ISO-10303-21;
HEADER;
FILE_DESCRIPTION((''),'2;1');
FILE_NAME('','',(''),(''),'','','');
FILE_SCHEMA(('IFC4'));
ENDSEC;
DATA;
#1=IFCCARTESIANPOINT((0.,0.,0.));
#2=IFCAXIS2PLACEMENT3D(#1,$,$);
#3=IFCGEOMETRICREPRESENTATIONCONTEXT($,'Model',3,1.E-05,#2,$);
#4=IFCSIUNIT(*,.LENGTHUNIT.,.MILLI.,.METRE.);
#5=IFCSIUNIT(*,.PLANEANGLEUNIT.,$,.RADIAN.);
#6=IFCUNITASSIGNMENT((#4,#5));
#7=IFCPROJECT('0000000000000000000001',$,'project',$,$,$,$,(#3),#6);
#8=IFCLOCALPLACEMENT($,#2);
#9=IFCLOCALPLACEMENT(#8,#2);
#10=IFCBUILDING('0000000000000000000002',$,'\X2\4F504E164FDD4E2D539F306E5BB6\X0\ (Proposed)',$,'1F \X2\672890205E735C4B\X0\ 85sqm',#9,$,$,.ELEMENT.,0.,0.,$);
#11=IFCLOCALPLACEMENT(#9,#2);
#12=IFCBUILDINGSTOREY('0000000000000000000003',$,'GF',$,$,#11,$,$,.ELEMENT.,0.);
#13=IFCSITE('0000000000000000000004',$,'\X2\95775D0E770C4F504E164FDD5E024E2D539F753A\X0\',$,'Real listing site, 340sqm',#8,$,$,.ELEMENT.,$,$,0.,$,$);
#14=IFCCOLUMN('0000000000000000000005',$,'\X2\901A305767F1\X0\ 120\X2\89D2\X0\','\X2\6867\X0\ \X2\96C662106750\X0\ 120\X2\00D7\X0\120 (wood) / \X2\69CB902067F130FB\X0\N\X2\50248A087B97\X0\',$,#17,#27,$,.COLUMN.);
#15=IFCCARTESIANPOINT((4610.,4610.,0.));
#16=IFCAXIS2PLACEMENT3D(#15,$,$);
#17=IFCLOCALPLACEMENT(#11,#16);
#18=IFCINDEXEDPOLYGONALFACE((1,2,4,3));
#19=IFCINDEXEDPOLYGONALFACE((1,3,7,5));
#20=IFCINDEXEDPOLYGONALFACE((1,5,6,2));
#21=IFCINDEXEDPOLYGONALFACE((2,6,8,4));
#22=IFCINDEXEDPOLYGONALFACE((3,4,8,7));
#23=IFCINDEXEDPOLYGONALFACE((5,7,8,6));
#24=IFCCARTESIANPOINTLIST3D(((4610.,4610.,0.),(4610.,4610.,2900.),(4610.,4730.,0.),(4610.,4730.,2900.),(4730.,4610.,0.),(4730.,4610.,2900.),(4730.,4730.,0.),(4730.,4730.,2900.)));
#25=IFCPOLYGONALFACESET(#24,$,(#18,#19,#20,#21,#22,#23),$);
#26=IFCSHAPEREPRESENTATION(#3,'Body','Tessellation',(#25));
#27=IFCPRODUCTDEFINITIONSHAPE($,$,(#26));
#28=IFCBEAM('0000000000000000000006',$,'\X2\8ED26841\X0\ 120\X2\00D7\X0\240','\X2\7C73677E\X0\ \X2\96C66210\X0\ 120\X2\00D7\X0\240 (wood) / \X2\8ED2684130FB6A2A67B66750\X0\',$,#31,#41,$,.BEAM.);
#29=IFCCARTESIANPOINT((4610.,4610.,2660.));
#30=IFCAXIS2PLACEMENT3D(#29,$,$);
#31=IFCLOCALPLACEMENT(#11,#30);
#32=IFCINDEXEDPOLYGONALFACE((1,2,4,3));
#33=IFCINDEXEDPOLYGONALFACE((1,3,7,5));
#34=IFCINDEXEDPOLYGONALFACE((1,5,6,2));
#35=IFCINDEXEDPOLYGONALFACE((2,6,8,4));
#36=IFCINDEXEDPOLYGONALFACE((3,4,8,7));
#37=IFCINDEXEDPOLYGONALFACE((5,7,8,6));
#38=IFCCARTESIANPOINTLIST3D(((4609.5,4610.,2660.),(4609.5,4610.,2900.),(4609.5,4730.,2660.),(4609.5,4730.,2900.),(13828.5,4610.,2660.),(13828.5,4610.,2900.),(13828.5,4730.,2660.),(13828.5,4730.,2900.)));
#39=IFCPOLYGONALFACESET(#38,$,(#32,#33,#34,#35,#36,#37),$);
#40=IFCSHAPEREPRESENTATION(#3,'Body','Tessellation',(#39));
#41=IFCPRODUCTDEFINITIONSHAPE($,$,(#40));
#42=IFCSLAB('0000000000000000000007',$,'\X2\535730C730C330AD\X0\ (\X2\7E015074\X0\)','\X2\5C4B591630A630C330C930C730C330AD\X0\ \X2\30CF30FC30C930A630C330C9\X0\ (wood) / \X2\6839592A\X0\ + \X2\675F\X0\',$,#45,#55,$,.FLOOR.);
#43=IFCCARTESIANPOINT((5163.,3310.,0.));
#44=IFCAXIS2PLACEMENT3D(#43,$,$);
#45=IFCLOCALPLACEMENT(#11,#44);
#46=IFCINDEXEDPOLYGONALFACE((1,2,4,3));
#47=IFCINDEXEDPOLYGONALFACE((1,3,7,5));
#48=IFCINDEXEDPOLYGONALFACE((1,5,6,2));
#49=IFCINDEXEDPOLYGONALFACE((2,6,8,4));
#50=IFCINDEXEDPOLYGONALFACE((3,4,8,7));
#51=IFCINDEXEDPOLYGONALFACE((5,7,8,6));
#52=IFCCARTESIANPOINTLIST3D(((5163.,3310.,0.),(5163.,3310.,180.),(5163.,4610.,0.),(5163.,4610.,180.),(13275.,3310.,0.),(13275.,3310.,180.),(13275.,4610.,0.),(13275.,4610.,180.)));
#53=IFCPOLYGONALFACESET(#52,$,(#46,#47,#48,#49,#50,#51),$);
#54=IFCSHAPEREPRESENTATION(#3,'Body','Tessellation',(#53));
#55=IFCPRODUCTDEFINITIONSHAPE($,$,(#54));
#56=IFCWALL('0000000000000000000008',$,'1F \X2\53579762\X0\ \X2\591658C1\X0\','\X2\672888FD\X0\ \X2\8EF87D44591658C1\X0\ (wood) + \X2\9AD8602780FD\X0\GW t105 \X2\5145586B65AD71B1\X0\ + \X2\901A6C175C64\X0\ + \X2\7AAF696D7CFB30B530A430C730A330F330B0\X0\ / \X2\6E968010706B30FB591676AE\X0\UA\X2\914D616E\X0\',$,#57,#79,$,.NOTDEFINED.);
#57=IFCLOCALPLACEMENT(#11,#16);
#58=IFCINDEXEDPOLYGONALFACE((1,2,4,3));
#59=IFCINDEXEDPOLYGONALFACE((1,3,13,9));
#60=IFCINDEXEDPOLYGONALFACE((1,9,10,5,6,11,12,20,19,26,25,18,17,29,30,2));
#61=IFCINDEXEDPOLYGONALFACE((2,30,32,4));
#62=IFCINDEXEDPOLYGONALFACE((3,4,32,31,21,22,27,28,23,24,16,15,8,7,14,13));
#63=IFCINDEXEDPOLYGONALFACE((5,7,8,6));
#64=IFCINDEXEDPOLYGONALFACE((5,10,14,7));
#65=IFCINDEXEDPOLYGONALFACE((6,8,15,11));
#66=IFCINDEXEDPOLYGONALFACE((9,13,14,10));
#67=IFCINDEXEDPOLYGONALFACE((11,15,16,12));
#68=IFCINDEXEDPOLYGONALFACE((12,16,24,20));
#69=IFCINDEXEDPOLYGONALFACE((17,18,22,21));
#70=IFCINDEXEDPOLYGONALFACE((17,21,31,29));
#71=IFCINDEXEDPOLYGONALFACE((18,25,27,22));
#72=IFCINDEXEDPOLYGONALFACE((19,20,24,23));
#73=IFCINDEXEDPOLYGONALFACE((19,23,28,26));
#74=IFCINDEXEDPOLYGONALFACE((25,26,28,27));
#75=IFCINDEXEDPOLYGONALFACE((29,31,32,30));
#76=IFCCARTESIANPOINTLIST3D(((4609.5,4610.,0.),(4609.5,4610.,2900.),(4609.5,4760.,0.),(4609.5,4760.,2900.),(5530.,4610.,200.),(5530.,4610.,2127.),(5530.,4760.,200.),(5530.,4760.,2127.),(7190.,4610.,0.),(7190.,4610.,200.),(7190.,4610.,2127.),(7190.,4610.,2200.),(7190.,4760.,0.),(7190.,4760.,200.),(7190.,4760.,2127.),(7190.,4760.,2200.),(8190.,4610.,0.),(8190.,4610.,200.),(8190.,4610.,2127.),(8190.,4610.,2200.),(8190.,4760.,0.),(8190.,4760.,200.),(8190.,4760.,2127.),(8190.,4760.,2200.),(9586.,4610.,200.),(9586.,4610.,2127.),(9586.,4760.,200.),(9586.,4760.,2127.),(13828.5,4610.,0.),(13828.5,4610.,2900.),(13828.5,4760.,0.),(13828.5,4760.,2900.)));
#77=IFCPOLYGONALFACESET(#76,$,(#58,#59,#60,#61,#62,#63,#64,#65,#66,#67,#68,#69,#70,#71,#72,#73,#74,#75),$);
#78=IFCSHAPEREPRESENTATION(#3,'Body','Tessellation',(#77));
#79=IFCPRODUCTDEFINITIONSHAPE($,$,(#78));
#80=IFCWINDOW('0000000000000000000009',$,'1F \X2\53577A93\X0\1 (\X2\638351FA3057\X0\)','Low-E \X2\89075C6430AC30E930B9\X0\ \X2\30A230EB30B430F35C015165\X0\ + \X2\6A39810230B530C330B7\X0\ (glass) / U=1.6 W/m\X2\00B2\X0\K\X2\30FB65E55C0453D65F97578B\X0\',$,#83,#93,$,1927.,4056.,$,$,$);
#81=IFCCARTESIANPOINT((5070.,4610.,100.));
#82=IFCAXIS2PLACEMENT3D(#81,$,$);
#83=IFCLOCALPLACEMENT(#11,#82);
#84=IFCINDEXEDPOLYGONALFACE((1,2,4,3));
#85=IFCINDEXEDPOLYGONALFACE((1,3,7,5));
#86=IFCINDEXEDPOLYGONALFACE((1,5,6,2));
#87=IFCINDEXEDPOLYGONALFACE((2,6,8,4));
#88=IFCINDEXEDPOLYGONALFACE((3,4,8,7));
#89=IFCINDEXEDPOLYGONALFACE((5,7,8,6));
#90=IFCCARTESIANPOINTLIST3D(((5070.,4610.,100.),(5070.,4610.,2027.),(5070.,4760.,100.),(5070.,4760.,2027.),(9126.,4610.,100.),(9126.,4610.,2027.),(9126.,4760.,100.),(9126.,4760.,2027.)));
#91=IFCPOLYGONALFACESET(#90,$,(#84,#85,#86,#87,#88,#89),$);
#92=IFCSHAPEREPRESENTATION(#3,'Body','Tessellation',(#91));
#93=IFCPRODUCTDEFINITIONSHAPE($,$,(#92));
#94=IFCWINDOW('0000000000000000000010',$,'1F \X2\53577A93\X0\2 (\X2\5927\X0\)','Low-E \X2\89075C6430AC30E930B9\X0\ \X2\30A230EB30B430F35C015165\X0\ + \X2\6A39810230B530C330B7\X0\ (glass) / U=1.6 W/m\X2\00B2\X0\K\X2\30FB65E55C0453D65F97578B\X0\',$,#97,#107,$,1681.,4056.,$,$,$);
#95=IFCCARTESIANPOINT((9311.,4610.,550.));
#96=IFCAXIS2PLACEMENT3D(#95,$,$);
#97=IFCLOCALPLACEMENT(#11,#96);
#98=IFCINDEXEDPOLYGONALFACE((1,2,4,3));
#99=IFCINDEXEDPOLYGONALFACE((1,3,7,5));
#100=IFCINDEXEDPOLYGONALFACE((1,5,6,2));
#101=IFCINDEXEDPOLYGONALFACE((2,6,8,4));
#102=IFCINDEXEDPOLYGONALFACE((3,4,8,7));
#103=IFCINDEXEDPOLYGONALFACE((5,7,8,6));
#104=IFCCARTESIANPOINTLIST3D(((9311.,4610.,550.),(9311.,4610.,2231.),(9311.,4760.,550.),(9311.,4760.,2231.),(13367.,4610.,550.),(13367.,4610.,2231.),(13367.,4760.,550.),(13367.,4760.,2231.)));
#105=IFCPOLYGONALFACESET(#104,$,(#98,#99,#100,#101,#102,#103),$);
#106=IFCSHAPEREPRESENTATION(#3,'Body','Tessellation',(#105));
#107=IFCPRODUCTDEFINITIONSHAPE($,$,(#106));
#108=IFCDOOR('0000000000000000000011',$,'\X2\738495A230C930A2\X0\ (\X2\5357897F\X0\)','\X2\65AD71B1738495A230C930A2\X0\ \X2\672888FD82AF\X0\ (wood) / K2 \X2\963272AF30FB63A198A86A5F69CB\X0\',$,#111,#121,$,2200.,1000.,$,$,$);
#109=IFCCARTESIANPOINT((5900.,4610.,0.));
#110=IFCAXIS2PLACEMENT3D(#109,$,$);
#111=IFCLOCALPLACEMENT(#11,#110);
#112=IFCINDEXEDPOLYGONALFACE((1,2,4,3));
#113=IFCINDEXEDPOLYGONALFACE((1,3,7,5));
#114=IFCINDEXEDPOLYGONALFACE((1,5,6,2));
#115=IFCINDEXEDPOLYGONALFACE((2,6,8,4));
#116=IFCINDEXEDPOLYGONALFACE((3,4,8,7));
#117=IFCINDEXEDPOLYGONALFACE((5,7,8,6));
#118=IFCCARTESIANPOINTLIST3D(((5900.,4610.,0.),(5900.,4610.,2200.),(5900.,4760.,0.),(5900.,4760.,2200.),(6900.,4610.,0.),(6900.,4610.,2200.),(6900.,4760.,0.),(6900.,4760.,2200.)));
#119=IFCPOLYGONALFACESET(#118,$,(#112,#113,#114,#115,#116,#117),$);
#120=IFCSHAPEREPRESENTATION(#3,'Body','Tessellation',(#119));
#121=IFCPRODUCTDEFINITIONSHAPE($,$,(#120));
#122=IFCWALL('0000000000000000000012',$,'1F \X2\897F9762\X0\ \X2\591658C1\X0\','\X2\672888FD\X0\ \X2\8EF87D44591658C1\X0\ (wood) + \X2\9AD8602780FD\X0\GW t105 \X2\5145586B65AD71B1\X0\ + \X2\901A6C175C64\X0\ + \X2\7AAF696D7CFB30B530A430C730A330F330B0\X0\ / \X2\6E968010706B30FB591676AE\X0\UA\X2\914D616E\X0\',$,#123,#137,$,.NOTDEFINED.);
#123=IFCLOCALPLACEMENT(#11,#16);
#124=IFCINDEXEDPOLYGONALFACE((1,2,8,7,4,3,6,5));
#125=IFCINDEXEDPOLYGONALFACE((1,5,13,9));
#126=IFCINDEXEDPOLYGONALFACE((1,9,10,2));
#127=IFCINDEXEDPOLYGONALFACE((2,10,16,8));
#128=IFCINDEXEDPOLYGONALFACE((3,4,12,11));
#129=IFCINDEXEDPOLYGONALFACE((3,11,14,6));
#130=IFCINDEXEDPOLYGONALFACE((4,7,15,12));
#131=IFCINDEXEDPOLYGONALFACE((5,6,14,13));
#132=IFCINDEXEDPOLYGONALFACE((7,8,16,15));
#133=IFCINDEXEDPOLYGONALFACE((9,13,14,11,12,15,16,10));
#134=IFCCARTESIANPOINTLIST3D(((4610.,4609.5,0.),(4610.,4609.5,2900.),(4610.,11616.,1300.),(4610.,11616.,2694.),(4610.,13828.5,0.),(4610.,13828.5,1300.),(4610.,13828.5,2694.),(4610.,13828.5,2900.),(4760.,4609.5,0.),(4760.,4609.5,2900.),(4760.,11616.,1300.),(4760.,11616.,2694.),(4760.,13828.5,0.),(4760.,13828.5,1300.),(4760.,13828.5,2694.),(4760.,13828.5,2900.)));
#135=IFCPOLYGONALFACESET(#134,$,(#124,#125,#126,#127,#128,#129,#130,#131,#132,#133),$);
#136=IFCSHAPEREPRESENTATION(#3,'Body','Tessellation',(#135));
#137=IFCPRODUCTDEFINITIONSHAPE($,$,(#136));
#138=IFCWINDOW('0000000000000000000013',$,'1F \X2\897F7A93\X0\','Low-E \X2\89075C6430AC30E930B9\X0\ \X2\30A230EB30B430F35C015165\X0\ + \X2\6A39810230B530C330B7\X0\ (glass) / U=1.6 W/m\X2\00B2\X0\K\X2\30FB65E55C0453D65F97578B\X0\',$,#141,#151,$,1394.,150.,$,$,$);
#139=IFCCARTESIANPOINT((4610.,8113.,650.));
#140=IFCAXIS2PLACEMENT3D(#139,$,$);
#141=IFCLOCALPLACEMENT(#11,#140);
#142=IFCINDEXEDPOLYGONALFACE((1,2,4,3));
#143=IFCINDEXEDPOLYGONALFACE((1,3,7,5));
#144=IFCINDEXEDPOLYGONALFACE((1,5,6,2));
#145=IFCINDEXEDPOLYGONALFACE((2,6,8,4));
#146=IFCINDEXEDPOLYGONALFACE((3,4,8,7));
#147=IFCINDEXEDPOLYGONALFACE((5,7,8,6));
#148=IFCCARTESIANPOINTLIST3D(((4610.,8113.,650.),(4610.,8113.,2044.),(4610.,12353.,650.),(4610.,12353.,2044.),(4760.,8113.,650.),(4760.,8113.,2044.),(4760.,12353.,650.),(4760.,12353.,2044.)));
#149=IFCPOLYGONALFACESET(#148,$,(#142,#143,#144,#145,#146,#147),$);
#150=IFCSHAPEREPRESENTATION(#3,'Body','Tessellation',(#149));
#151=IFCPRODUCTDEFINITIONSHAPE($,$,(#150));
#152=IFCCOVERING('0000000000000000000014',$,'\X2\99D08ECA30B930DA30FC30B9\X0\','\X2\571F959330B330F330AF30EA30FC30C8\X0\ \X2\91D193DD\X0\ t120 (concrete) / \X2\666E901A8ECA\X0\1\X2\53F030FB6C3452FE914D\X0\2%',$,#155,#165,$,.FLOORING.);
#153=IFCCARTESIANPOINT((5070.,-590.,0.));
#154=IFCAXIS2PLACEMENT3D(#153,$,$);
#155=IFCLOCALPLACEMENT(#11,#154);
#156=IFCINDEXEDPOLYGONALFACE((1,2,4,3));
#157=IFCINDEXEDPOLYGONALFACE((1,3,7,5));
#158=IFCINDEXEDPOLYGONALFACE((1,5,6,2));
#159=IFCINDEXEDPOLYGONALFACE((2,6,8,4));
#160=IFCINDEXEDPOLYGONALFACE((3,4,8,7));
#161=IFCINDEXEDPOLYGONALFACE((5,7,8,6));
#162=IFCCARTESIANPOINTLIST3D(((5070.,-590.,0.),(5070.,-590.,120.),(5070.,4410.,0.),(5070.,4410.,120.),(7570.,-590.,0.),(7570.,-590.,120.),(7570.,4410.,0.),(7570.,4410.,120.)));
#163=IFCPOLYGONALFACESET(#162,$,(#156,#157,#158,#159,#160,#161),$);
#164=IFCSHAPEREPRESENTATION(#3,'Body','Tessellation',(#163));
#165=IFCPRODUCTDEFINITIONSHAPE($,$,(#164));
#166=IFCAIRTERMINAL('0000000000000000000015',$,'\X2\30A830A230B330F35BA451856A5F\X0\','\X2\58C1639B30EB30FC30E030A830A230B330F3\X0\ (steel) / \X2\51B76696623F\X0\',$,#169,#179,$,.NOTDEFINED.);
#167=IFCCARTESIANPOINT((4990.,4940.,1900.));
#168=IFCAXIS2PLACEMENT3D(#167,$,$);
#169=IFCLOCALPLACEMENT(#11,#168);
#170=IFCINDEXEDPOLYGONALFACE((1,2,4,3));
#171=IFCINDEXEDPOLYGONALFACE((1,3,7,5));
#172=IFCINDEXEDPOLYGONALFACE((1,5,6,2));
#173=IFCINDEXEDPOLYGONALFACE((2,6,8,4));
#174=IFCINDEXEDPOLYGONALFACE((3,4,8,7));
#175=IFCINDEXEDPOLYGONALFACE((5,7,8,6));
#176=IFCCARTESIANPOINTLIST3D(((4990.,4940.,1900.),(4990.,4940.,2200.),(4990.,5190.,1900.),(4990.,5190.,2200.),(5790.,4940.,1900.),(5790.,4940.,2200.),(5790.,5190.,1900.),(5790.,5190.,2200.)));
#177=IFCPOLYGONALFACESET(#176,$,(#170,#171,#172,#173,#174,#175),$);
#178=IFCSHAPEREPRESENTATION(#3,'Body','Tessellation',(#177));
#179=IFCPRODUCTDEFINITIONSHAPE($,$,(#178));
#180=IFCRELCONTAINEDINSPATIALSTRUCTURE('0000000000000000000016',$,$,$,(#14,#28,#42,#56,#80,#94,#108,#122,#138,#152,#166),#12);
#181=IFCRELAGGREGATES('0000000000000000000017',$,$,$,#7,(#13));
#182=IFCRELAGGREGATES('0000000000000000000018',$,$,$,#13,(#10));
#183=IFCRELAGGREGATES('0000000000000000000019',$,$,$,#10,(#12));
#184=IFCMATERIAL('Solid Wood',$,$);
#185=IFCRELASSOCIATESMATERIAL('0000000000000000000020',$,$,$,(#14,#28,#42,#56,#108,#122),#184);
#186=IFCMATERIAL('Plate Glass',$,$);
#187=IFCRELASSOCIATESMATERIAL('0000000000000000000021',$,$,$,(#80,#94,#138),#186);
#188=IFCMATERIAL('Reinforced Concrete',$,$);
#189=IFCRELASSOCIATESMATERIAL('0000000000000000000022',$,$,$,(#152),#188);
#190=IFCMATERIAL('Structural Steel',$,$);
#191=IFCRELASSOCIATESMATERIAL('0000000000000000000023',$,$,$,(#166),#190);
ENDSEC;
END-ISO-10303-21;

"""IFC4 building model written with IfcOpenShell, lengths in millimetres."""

from ifc_helpers import new_model, si_unit, frame, frame_2d, origin, place, context, project, spatial, rectangle, extrude, material, element, fill, save


model = new_model("IFC4")

# Units and contexts
model_context = context("Model", 3, precision=1e-05, world=origin())
ifc_project = project(units=[si_unit("LENGTHUNIT", "METRE", prefix="MILLI"), si_unit("PLANEANGLEUNIT", "RADIAN")], contexts=[model_context])

# Site, building, storey
site_placement = place(None, origin())
site = spatial("IfcSite", under=ifc_project, at=site_placement, Name="長崎県佐世保市中原町", ObjectType="Real listing site, 340sqm", CompositionType="ELEMENT", RefElevation=0.0)
building_placement = place(site_placement, origin())
building = spatial("IfcBuilding", under=site, at=building_placement, Name="佐世保中原の家 (Proposed)", ObjectType="1F 木造平屋 85sqm", CompositionType="ELEMENT", ElevationOfRefHeight=0.0, ElevationOfTerrain=0.0)
storey_placement = place(building_placement, origin())
storey = spatial("IfcBuildingStorey", under=building, at=storey_placement, Name="GF", CompositionType="ELEMENT", Elevation=0.0)

# Column
ifc_material_1 = material(Name="Solid Wood")
column_1_placement = place(storey_placement, frame((4610.0, 4610.0, 0.0)))
element("IfcColumn", 1, at=column_1_placement, inside=storey, material=ifc_material_1, Name="通し柱 120角", Description="桧 集成材 120×120 (wood) / 構造柱・N値計算", PredefinedType="COLUMN", context=model_context, shape_type="SweptSolid", body=[
    extrude(rectangle(XDim=120.0, YDim=120.0, at=frame_2d((60.0, 60.0))), frame((4610.0, 4610.0, 0.0)), (0.0, 0.0, 1.0), 2900.0),
])

# Beam
beam_1_placement = place(storey_placement, frame((4610.0, 4610.0, 2660.0)))
element("IfcBeam", 2, at=beam_1_placement, inside=storey, material=ifc_material_1, Name="軒桁 120×240", Description="米松 集成 120×240 (wood) / 軒桁・横架材", PredefinedType="BEAM", context=model_context, shape_type="SweptSolid", body=[
    extrude(rectangle(XDim=9219.0, YDim=120.0, at=frame_2d((4609.0, 60.0))), frame((4610.0, 4610.0, 2660.0)), (0.0, 0.0, 1.0), 240.0),
])

# Slab
ifc_material_2 = material(Name="Reinforced Concrete")
slab_1_placement = place(storey_placement, frame((5163.0, 3310.0, 0.0)))
element("IfcSlab", 3, at=slab_1_placement, inside=storey, material=ifc_material_1, Name="南デッキ (縁側)", Description="屋外ウッドデッキ ハードウッド (wood) / 根太 + 束", PredefinedType="FLOOR", context=model_context, shape_type="SweptSolid", body=[
    extrude(rectangle(XDim=8112.0, YDim=1300.0, at=frame_2d((4056.0, 650.0))), frame((5163.0, 3310.0, 0.0)), (0.0, 0.0, 1.0), 180.0),
])

# Wall, openings, windows, door
wall_1_placement = place(storey_placement, frame((4610.0, 4610.0, 0.0)))
wall_1 = element("IfcWall", 4, at=wall_1_placement, inside=storey, material=ifc_material_1, Name="1F 南面 外壁", Description="木製 軸組外壁 (wood) + 高性能GW t105 充填断熱 + 通気層 + 窯業系サイディング / 準耐火・外皮UA配慮", PredefinedType="NOTDEFINED", context=model_context, shape_type="SweptSolid", body=[
    extrude(rectangle(XDim=9219.0, YDim=150.0, at=frame_2d((4609.0, 75.0))), frame((4610.0, 4610.0, 0.0)), (0.0, 0.0, 1.0), 2900.0),
])
opening_1_placement = place(storey_placement, frame((5070.0, 4610.0, 100.0)))
opening_1 = element("IfcOpeningElement", 5, at=opening_1_placement, cuts=wall_1, PredefinedType="NOTDEFINED", context=model_context, shape_type="SweptSolid", body=[
    extrude(rectangle(XDim=4056.0, YDim=150.0, at=frame_2d((2028.0, 75.0))), frame((5070.0, 4610.0, 100.0)), (0.0, 0.0, 1.0), 1927.0),
])
opening_2_placement = place(storey_placement, frame((9311.0, 4610.0, 550.0)))
opening_2 = element("IfcOpeningElement", 6, at=opening_2_placement, cuts=wall_1, PredefinedType="NOTDEFINED", context=model_context, shape_type="SweptSolid", body=[
    extrude(rectangle(XDim=4056.0, YDim=150.0, at=frame_2d((2028.0, 75.0))), frame((9311.0, 4610.0, 550.0)), (0.0, 0.0, 1.0), 1681.0),
])
opening_3_placement = place(storey_placement, frame((5900.0, 4610.0, 0.0)))
opening_3 = element("IfcOpeningElement", 7, at=opening_3_placement, cuts=wall_1, PredefinedType="NOTDEFINED", context=model_context, shape_type="SweptSolid", body=[
    extrude(rectangle(XDim=1000.0, YDim=150.0, at=frame_2d((500.0, 75.0))), frame((5900.0, 4610.0, 0.0)), (0.0, 0.0, 1.0), 2200.0),
])
ifc_material_3 = material(Name="Plate Glass")
window_1_placement = place(storey_placement, frame((5070.0, 4610.0, 100.0)))
window_1 = element("IfcWindow", 8, at=window_1_placement, inside=storey, material=ifc_material_3, Name="1F 南窓1 (掃出し)", Description="Low-E 複層ガラス アルゴン封入 + 樹脂サッシ (glass) / U=1.6 W/m²K・日射取得型", OverallHeight=1927.0, OverallWidth=4056.0, context=model_context, shape_type="SweptSolid", body=[
    extrude(rectangle(XDim=4056.0, YDim=150.0, at=frame_2d((2028.0, 75.0))), frame((5070.0, 4610.0, 100.0)), (0.0, 0.0, 1.0), 1927.0),
])
fill(opening_1, window_1)
window_2_placement = place(storey_placement, frame((9311.0, 4610.0, 550.0)))
window_2 = element("IfcWindow", 9, at=window_2_placement, inside=storey, material=ifc_material_3, Name="1F 南窓2 (大)", Description="Low-E 複層ガラス アルゴン封入 + 樹脂サッシ (glass) / U=1.6 W/m²K・日射取得型", OverallHeight=1681.0, OverallWidth=4056.0, context=model_context, shape_type="SweptSolid", body=[
    extrude(rectangle(XDim=4056.0, YDim=150.0, at=frame_2d((2028.0, 75.0))), frame((9311.0, 4610.0, 550.0)), (0.0, 0.0, 1.0), 1681.0),
])
fill(opening_2, window_2)
door_placement = place(storey_placement, frame((5900.0, 4610.0, 0.0)))
door = element("IfcDoor", 10, at=door_placement, inside=storey, material=ifc_material_1, Name="玄関ドア (南西)", Description="断熱玄関ドア 木製芯 (wood) / K2 防犯・採風機構", OverallHeight=2200.0, OverallWidth=1000.0, context=model_context, shape_type="SweptSolid", body=[
    extrude(rectangle(XDim=1000.0, YDim=150.0, at=frame_2d((500.0, 75.0))), frame((5900.0, 4610.0, 0.0)), (0.0, 0.0, 1.0), 2200.0),
])
fill(opening_3, door)

# Wall, opening, window
wall_2_placement = place(storey_placement, frame((4610.0, 4610.0, 0.0)))
wall_2 = element("IfcWall", 11, at=wall_2_placement, inside=storey, material=ifc_material_1, Name="1F 西面 外壁", Description="木製 軸組外壁 (wood) + 高性能GW t105 充填断熱 + 通気層 + 窯業系サイディング / 準耐火・外皮UA配慮", PredefinedType="NOTDEFINED", context=model_context, shape_type="SweptSolid", body=[
    extrude(rectangle(XDim=150.0, YDim=9219.0, at=frame_2d((75.0, 4609.0))), frame((4610.0, 4610.0, 0.0)), (0.0, 0.0, 1.0), 2900.0),
])
opening_4_placement = place(storey_placement, frame((4610.0, 8113.0, 650.0)))
opening_4 = element("IfcOpeningElement", 12, at=opening_4_placement, cuts=wall_2, PredefinedType="NOTDEFINED", context=model_context, shape_type="SweptSolid", body=[
    extrude(rectangle(XDim=150.0, YDim=4240.0, at=frame_2d((75.0, 2120.0))), frame((4610.0, 8113.0, 650.0)), (0.0, 0.0, 1.0), 1394.0),
])
window_3_placement = place(storey_placement, frame((4610.0, 8113.0, 650.0)))
window_3 = element("IfcWindow", 13, at=window_3_placement, inside=storey, material=ifc_material_3, Name="1F 西窓", Description="Low-E 複層ガラス アルゴン封入 + 樹脂サッシ (glass) / U=1.6 W/m²K・日射取得型", OverallHeight=1394.0, OverallWidth=150.0, context=model_context, shape_type="SweptSolid", body=[
    extrude(rectangle(XDim=150.0, YDim=4240.0, at=frame_2d((75.0, 2120.0))), frame((4610.0, 8113.0, 650.0)), (0.0, 0.0, 1.0), 1394.0),
])
fill(opening_4, window_3)

# Shared definitions
ifc_material_4 = material(Name="Structural Steel")

# Covering
covering_1_placement = place(storey_placement, frame((5070.0, -590.0, 0.0)))
element("IfcCovering", 14, at=covering_1_placement, inside=storey, material=ifc_material_2, Name="駐車スペース", Description="土間コンクリート 金鏝 t120 (concrete) / 普通車1台・水勾配2%", PredefinedType="FLOORING", context=model_context, shape_type="SweptSolid", body=[
    extrude(rectangle(XDim=2500.0, YDim=5000.0, at=frame_2d((1250.0, 2500.0))), frame((5070.0, -590.0, 0.0)), (0.0, 0.0, 1.0), 120.0),
])

# Air terminal
air_terminal_placement = place(storey_placement, frame((4990.0, 4940.0, 1900.0)))
element("IfcAirTerminal", 15, at=air_terminal_placement, inside=storey, material=ifc_material_4, Name="エアコン室内機", Description="壁掛ルームエアコン (steel) / 冷暖房", PredefinedType="NOTDEFINED", context=model_context, shape_type="SweptSolid", body=[
    extrude(rectangle(XDim=800.0, YDim=250.0, at=frame_2d((400.0, 125.0))), frame((4990.0, 4940.0, 1900.0)), (0.0, 0.0, 1.0), 300.0),
])

save(model, "model.ifc")
